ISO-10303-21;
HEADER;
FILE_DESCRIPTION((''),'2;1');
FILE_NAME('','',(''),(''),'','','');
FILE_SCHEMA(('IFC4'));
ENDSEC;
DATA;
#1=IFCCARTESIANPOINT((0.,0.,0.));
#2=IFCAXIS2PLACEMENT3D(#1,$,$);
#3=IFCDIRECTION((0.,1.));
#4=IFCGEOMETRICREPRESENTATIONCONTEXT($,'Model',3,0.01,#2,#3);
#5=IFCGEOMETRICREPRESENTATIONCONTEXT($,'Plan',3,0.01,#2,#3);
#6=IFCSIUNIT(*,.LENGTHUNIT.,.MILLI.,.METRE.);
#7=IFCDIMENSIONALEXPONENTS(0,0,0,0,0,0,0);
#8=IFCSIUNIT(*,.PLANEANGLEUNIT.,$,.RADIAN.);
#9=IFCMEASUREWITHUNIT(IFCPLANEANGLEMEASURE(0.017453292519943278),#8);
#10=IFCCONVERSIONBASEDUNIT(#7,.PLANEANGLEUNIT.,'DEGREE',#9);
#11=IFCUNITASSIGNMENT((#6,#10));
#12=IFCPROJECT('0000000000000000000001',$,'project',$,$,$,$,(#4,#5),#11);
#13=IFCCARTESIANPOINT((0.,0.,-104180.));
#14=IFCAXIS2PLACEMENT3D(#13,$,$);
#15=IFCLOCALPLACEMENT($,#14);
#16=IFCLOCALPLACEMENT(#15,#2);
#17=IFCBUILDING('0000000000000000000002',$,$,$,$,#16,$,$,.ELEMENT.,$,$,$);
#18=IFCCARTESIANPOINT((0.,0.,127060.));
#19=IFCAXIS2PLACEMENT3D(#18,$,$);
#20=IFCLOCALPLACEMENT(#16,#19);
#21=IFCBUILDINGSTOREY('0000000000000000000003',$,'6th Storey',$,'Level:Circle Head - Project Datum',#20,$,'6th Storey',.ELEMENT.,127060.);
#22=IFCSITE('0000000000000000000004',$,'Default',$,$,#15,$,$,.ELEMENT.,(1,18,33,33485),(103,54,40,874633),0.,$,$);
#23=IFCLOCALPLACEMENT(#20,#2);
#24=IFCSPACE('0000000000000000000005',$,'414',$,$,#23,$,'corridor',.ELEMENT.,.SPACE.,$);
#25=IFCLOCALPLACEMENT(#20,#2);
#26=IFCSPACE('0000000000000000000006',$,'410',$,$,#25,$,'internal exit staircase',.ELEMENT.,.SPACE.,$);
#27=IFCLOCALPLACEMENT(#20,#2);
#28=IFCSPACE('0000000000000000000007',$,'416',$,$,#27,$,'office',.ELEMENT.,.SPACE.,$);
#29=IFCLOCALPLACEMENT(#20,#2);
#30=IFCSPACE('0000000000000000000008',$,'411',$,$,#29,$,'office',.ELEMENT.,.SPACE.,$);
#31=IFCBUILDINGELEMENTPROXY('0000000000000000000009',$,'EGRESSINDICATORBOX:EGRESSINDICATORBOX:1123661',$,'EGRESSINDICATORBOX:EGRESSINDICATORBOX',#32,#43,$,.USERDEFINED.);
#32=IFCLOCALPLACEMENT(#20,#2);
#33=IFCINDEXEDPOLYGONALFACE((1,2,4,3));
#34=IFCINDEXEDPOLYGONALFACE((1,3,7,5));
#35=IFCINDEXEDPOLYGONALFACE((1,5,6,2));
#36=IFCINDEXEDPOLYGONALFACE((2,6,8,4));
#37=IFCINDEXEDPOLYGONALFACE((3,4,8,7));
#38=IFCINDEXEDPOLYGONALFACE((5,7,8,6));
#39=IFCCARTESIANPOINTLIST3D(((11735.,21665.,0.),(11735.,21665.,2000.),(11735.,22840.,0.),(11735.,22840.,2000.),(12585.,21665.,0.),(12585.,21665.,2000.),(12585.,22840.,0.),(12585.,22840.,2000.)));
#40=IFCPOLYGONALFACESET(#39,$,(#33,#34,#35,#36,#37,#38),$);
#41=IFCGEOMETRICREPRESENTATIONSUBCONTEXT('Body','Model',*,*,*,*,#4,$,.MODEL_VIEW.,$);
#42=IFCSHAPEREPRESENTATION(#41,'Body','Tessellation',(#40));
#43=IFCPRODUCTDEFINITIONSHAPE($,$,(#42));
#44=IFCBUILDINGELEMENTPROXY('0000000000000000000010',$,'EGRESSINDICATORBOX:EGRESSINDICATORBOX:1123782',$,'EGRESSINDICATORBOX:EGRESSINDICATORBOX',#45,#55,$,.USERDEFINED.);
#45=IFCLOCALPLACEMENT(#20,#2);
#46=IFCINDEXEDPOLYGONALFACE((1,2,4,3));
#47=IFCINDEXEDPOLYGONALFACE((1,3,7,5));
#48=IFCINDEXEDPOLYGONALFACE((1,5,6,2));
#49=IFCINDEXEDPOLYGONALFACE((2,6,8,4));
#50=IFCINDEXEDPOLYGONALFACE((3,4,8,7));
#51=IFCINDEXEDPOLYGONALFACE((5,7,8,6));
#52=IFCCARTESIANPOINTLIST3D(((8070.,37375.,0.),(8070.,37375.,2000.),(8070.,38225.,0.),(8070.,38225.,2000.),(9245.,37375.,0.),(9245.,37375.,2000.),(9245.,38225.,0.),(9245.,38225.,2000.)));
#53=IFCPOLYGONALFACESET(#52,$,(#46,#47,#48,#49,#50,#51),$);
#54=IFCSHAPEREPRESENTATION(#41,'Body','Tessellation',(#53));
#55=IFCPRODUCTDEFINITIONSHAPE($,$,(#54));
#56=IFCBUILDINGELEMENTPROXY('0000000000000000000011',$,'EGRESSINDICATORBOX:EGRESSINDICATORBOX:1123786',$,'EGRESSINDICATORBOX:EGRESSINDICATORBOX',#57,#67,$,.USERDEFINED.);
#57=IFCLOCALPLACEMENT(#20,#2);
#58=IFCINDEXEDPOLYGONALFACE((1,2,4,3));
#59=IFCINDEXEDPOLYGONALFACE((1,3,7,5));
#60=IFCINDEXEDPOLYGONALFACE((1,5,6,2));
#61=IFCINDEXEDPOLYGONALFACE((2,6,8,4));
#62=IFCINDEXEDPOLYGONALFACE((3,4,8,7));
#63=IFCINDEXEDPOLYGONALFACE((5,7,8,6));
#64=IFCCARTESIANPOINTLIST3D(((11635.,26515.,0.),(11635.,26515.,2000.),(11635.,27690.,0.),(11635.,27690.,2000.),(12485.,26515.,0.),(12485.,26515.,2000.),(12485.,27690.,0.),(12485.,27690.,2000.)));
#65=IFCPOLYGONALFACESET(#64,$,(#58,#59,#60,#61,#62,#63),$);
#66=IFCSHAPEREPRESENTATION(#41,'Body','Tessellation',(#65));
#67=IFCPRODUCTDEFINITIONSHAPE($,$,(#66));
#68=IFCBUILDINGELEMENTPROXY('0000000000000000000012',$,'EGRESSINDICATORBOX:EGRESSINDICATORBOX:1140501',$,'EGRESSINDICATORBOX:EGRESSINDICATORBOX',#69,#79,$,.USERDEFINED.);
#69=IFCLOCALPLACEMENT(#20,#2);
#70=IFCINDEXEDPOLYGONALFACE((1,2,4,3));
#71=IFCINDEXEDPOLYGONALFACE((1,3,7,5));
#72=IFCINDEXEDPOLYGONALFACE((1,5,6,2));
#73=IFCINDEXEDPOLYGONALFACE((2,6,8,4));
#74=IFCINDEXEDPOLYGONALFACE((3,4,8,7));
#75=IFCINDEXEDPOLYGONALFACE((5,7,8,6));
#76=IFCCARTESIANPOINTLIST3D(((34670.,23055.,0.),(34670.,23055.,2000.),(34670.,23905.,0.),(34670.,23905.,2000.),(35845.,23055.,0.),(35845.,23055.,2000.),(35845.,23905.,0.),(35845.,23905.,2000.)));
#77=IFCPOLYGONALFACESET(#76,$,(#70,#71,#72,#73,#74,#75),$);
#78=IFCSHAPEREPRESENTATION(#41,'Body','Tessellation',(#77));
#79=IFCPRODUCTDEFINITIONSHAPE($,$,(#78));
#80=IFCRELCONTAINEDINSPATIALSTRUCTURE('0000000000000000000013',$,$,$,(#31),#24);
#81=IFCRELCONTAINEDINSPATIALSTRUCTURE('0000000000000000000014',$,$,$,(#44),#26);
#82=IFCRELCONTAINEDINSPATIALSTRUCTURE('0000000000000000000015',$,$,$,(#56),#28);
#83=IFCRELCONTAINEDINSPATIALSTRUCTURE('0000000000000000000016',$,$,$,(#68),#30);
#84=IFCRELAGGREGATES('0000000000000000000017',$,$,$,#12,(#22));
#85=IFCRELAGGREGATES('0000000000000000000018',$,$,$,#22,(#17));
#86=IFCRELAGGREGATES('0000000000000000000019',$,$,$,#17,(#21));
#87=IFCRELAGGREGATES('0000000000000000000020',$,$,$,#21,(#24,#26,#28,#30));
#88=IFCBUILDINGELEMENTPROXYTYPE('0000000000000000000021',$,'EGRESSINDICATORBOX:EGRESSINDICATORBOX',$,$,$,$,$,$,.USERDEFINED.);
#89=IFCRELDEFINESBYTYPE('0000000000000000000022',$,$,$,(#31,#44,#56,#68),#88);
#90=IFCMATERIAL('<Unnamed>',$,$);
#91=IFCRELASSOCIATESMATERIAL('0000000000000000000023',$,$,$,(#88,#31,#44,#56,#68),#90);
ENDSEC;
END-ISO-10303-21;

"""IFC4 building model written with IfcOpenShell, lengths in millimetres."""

from ifc_helpers import new_model, entity, si_unit, converted_unit, direction, frame, origin, place, context, subcontext, project, spatial, indexed_curve, outline, extrude, source, transform, mapped, material, type_object, type_shapes, element, save


model = new_model("IFC4")

# Units and contexts
model_context = context("Model", 3, precision=0.01, world=origin(), true_north=direction((0.0, 1.0)))
plan_context = context("Plan", 3, precision=0.01, world=origin(), true_north=direction((0.0, 1.0)))
body_context = subcontext(model_context, "Body", "Model", "MODEL_VIEW")
ifc_project = project(units=[si_unit("LENGTHUNIT", "METRE", prefix="MILLI"), converted_unit("PLANEANGLEUNIT", "DEGREE", entity("IfcPlaneAngleMeasure", 0.017453292519943278), si_unit("PLANEANGLEUNIT", "RADIAN"), dimensions=[0, 0, 0, 0, 0, 0, 0])], contexts=[model_context, plan_context])

# Site, building, storey
site_placement = place(None, frame((0.0, 0.0, -104180.0)))
site = spatial("IfcSite", under=ifc_project, at=site_placement, Name="Default", CompositionType="ELEMENT", RefLatitude=(1, 18, 33, 33485), RefLongitude=(103, 54, 40, 874633), RefElevation=0.0)
building_placement = place(site_placement, origin())
building = spatial("IfcBuilding", under=site, at=building_placement, CompositionType="ELEMENT")
storey_placement = place(building_placement, frame((0.0, 0.0, 127060.0)))
storey = spatial("IfcBuildingStorey", under=building, at=storey_placement, Name="6th Storey", ObjectType="Level:Circle Head - Project Datum", LongName="6th Storey", CompositionType="ELEMENT", Elevation=127060.0)

# Shared definitions
ifc_material_1 = material(Name="<Unnamed>")

# Shared definitions
building_element_proxy_type_1 = type_object("IfcBuildingElementProxyType", Name="EGRESSINDICATORBOX:EGRESSINDICATORBOX", PredefinedType="USERDEFINED", material=ifc_material_1)
shared_shape_1 = source(origin(), body_context, "Body", "SweptSolid", [
    extrude(outline(indexed_curve([(-425.0, -587.5), (425.0, -587.5), (425.0, 587.5), (-425.0, 587.5), (-425.0, -587.5)], self_intersect=False)), frame((0.0, 0.0, 0.0), z_axis=(0.0, 0.0, 1.0), x_axis=(-1.0, 0.0, 0.0)), (0.0, 0.0, 1.0), 2000.0),
])
type_shapes(building_element_proxy_type_1, [shared_shape_1])

# Shared definitions
space_1_placement = place(storey_placement, origin())
space_1 = spatial("IfcSpace", under=storey, at=space_1_placement, Name="414", LongName="corridor", CompositionType="ELEMENT", PredefinedType="SPACE")

# Building element proxy
proxy_1_placement = place(space_1_placement, frame((12160.0, 22252.5, 0.0)))
element("IfcBuildingElementProxy", 1, at=proxy_1_placement, inside=space_1, type_object=building_element_proxy_type_1, material=ifc_material_1, Name="EGRESSINDICATORBOX:EGRESSINDICATORBOX:1123661", ObjectType="EGRESSINDICATORBOX:EGRESSINDICATORBOX", PredefinedType="USERDEFINED", context=body_context, shape_type="MappedRepresentation", body=[
    mapped(shared_shape_1, transform((0.0, 0.0, 0.0), scale=1.0)),
])

# Shared definitions
space_2_placement = place(storey_placement, origin())
space_2 = spatial("IfcSpace", under=storey, at=space_2_placement, Name="410", LongName="internal exit staircase", CompositionType="ELEMENT", PredefinedType="SPACE")

# Building element proxy
proxy_2_placement = place(space_2_placement, frame((8657.5, 37800.0, 0.0), z_axis=(0.0, 0.0, 1.0), x_axis=(0.0, 1.0, 0.0)))
element("IfcBuildingElementProxy", 2, at=proxy_2_placement, inside=space_2, type_object=building_element_proxy_type_1, material=ifc_material_1, Name="EGRESSINDICATORBOX:EGRESSINDICATORBOX:1123782", ObjectType="EGRESSINDICATORBOX:EGRESSINDICATORBOX", PredefinedType="USERDEFINED", context=body_context, shape_type="MappedRepresentation", body=[
    mapped(shared_shape_1, transform((0.0, 0.0, 0.0), scale=1.0)),
])

# Shared definitions
space_3_placement = place(storey_placement, origin())
space_3 = spatial("IfcSpace", under=storey, at=space_3_placement, Name="416", LongName="office", CompositionType="ELEMENT", PredefinedType="SPACE")

# Building element proxy
proxy_3_placement = place(space_3_placement, frame((12060.0, 27102.5, 0.0)))
element("IfcBuildingElementProxy", 3, at=proxy_3_placement, inside=space_3, type_object=building_element_proxy_type_1, material=ifc_material_1, Name="EGRESSINDICATORBOX:EGRESSINDICATORBOX:1123786", ObjectType="EGRESSINDICATORBOX:EGRESSINDICATORBOX", PredefinedType="USERDEFINED", context=body_context, shape_type="MappedRepresentation", body=[
    mapped(shared_shape_1, transform((0.0, 0.0, 0.0), scale=1.0)),
])

# Shared definitions
space_4_placement = place(storey_placement, origin())
space_4 = spatial("IfcSpace", under=storey, at=space_4_placement, Name="411", LongName="office", CompositionType="ELEMENT", PredefinedType="SPACE")

# Building element proxy
proxy_4_placement = place(space_4_placement, frame((35257.5, 23480.0, 0.0), z_axis=(0.0, 0.0, 1.0), x_axis=(0.0, -1.0, 0.0)))
element("IfcBuildingElementProxy", 4, at=proxy_4_placement, inside=space_4, type_object=building_element_proxy_type_1, material=ifc_material_1, Name="EGRESSINDICATORBOX:EGRESSINDICATORBOX:1140501", ObjectType="EGRESSINDICATORBOX:EGRESSINDICATORBOX", PredefinedType="USERDEFINED", context=body_context, shape_type="MappedRepresentation", body=[
    mapped(shared_shape_1, transform((0.0, 0.0, 0.0), scale=1.0)),
])

save(model, "model.ifc")
